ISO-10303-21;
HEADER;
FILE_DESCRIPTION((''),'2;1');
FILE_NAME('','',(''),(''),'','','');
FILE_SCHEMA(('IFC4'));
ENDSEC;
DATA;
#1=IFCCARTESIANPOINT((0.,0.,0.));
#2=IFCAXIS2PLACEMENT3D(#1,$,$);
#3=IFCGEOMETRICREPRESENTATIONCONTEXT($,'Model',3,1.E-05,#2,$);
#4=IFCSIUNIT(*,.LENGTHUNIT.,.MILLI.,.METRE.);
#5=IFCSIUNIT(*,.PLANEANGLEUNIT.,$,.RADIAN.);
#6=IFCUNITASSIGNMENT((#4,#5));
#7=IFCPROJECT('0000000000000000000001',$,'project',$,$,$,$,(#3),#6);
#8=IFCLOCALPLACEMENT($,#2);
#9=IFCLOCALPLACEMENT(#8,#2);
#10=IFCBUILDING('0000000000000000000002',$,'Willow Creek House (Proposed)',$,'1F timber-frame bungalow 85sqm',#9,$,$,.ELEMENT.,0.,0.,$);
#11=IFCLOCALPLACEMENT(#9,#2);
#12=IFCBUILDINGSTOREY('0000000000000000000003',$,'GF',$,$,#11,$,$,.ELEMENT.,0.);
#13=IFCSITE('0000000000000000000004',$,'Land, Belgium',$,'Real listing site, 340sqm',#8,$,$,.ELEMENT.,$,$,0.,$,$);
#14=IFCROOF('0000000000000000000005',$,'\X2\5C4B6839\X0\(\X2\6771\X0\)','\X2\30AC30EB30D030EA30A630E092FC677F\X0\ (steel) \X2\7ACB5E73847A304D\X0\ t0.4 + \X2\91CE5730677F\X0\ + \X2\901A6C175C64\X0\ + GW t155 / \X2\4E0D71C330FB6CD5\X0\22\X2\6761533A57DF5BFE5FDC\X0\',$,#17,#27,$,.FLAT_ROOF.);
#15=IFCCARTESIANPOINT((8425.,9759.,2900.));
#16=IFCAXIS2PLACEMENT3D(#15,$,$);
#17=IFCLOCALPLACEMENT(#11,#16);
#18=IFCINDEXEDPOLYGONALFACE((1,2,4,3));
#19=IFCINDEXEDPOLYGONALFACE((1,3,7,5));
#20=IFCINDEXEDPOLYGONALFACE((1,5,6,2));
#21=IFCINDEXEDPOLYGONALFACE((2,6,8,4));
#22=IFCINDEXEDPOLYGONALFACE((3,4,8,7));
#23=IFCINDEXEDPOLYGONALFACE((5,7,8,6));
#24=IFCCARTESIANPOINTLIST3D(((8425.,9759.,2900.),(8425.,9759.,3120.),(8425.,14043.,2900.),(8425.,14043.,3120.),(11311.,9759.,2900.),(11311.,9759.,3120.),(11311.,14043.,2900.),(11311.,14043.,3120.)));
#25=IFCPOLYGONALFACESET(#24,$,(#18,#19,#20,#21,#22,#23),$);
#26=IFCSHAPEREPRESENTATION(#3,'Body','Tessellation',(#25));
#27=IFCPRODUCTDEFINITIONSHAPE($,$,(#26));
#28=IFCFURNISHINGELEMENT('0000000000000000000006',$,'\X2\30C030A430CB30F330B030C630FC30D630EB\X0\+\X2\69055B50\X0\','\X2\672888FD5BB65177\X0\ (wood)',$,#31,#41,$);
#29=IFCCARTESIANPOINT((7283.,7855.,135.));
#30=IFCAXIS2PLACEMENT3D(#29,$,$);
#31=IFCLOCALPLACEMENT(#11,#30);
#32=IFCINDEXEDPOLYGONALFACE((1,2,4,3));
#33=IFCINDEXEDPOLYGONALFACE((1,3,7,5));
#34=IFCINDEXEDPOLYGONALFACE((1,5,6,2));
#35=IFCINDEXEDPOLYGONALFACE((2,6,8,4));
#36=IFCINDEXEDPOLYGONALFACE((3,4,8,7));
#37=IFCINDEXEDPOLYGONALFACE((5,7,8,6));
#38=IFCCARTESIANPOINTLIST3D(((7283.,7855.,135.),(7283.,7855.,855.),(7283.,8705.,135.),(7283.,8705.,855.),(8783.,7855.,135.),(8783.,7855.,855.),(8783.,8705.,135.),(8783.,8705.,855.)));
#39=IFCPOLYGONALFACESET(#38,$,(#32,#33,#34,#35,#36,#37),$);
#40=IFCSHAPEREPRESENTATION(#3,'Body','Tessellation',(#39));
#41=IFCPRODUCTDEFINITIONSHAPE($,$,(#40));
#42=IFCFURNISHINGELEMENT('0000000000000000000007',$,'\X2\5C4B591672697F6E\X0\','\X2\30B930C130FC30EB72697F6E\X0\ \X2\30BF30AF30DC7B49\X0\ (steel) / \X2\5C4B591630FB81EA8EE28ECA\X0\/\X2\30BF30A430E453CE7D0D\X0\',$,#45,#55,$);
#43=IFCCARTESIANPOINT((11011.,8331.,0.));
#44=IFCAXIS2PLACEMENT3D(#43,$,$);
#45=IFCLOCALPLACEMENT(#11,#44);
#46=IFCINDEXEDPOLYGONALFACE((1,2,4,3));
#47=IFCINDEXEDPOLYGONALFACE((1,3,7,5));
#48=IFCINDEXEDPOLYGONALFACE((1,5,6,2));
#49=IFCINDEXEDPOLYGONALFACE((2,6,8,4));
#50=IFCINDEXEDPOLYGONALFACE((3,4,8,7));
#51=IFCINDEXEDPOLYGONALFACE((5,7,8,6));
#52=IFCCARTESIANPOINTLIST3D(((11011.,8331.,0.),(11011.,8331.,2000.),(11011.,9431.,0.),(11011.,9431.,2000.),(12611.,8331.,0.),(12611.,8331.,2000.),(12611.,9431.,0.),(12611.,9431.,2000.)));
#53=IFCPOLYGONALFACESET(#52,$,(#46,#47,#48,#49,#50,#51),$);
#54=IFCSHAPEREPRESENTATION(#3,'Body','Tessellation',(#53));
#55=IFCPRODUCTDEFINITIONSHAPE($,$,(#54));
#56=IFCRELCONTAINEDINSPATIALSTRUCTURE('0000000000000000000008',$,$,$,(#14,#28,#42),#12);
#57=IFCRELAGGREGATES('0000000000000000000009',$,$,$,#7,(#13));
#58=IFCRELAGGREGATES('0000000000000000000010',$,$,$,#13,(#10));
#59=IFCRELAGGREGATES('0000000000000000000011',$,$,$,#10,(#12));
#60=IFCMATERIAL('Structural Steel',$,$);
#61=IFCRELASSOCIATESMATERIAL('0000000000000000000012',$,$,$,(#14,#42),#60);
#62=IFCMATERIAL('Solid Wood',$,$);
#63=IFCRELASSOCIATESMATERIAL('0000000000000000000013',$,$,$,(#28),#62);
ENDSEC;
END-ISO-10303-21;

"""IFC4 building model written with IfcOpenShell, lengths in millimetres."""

from ifc_helpers import new_model, si_unit, frame, frame_2d, origin, place, context, project, spatial, rectangle, extrude, material, element, save


model = new_model("IFC4")

# Units and contexts
model_context = context("Model", 3, precision=1e-05, world=origin())
ifc_project = project(units=[si_unit("LENGTHUNIT", "METRE", prefix="MILLI"), si_unit("PLANEANGLEUNIT", "RADIAN")], contexts=[model_context])

# Site, building, storey
site_placement = place(None, origin())
site = spatial("IfcSite", under=ifc_project, at=site_placement, Name="Land, Belgium", ObjectType="Real listing site, 340sqm", CompositionType="ELEMENT", RefElevation=0.0)
building_placement = place(site_placement, origin())
building = spatial("IfcBuilding", under=site, at=building_placement, Name="Willow Creek House (Proposed)", ObjectType="1F timber-frame bungalow 85sqm", CompositionType="ELEMENT", ElevationOfRefHeight=0.0, ElevationOfTerrain=0.0)
storey_placement = place(building_placement, origin())
storey = spatial("IfcBuildingStorey", under=building, at=storey_placement, Name="GF", CompositionType="ELEMENT", Elevation=0.0)

# Shared definitions
ifc_material_1 = material(Name="Solid Wood")

# Roof
ifc_material_2 = material(Name="Structural Steel")
roof_1_placement = place(storey_placement, frame((8425.0, 9759.0, 2900.0)))
element("IfcRoof", 1, at=roof_1_placement, inside=storey, material=ifc_material_2, Name="屋根(東)", Description="ガルバリウム鋼板 (steel) 立平葺き t0.4 + 野地板 + 通気層 + GW t155 / 不燃・法22条区域対応", PredefinedType="FLAT_ROOF", context=model_context, shape_type="SweptSolid", body=[
    extrude(rectangle(XDim=2886.0, YDim=4284.0, at=frame_2d((1443.0, 2142.0))), frame((8425.0, 9759.0, 2900.0)), (0.0, 0.0, 1.0), 220.0),
])

# Furnishing elements
furnishing_1_placement = place(storey_placement, frame((7283.0, 7855.0, 135.0)))
element("IfcFurnishingElement", 2, at=furnishing_1_placement, inside=storey, material=ifc_material_1, Name="ダイニングテーブル+椅子", Description="木製家具 (wood)", context=model_context, shape_type="SweptSolid", body=[
    extrude(rectangle(XDim=1500.0, YDim=850.0, at=frame_2d((750.0, 425.0))), frame((7283.0, 7855.0, 135.0)), (0.0, 0.0, 1.0), 720.0),
])
furnishing_2_placement = place(storey_placement, frame((11011.0, 8331.0, 0.0)))
element("IfcFurnishingElement", 3, at=furnishing_2_placement, inside=storey, material=ifc_material_2, Name="屋外物置", Description="スチール物置 タクボ等 (steel) / 屋外・自転車/タイヤ収納", context=model_context, shape_type="SweptSolid", body=[
    extrude(rectangle(XDim=1600.0, YDim=1100.0, at=frame_2d((800.0, 550.0))), frame((11011.0, 8331.0, 0.0)), (0.0, 0.0, 1.0), 2000.0),
])

save(model, "model.ifc")
